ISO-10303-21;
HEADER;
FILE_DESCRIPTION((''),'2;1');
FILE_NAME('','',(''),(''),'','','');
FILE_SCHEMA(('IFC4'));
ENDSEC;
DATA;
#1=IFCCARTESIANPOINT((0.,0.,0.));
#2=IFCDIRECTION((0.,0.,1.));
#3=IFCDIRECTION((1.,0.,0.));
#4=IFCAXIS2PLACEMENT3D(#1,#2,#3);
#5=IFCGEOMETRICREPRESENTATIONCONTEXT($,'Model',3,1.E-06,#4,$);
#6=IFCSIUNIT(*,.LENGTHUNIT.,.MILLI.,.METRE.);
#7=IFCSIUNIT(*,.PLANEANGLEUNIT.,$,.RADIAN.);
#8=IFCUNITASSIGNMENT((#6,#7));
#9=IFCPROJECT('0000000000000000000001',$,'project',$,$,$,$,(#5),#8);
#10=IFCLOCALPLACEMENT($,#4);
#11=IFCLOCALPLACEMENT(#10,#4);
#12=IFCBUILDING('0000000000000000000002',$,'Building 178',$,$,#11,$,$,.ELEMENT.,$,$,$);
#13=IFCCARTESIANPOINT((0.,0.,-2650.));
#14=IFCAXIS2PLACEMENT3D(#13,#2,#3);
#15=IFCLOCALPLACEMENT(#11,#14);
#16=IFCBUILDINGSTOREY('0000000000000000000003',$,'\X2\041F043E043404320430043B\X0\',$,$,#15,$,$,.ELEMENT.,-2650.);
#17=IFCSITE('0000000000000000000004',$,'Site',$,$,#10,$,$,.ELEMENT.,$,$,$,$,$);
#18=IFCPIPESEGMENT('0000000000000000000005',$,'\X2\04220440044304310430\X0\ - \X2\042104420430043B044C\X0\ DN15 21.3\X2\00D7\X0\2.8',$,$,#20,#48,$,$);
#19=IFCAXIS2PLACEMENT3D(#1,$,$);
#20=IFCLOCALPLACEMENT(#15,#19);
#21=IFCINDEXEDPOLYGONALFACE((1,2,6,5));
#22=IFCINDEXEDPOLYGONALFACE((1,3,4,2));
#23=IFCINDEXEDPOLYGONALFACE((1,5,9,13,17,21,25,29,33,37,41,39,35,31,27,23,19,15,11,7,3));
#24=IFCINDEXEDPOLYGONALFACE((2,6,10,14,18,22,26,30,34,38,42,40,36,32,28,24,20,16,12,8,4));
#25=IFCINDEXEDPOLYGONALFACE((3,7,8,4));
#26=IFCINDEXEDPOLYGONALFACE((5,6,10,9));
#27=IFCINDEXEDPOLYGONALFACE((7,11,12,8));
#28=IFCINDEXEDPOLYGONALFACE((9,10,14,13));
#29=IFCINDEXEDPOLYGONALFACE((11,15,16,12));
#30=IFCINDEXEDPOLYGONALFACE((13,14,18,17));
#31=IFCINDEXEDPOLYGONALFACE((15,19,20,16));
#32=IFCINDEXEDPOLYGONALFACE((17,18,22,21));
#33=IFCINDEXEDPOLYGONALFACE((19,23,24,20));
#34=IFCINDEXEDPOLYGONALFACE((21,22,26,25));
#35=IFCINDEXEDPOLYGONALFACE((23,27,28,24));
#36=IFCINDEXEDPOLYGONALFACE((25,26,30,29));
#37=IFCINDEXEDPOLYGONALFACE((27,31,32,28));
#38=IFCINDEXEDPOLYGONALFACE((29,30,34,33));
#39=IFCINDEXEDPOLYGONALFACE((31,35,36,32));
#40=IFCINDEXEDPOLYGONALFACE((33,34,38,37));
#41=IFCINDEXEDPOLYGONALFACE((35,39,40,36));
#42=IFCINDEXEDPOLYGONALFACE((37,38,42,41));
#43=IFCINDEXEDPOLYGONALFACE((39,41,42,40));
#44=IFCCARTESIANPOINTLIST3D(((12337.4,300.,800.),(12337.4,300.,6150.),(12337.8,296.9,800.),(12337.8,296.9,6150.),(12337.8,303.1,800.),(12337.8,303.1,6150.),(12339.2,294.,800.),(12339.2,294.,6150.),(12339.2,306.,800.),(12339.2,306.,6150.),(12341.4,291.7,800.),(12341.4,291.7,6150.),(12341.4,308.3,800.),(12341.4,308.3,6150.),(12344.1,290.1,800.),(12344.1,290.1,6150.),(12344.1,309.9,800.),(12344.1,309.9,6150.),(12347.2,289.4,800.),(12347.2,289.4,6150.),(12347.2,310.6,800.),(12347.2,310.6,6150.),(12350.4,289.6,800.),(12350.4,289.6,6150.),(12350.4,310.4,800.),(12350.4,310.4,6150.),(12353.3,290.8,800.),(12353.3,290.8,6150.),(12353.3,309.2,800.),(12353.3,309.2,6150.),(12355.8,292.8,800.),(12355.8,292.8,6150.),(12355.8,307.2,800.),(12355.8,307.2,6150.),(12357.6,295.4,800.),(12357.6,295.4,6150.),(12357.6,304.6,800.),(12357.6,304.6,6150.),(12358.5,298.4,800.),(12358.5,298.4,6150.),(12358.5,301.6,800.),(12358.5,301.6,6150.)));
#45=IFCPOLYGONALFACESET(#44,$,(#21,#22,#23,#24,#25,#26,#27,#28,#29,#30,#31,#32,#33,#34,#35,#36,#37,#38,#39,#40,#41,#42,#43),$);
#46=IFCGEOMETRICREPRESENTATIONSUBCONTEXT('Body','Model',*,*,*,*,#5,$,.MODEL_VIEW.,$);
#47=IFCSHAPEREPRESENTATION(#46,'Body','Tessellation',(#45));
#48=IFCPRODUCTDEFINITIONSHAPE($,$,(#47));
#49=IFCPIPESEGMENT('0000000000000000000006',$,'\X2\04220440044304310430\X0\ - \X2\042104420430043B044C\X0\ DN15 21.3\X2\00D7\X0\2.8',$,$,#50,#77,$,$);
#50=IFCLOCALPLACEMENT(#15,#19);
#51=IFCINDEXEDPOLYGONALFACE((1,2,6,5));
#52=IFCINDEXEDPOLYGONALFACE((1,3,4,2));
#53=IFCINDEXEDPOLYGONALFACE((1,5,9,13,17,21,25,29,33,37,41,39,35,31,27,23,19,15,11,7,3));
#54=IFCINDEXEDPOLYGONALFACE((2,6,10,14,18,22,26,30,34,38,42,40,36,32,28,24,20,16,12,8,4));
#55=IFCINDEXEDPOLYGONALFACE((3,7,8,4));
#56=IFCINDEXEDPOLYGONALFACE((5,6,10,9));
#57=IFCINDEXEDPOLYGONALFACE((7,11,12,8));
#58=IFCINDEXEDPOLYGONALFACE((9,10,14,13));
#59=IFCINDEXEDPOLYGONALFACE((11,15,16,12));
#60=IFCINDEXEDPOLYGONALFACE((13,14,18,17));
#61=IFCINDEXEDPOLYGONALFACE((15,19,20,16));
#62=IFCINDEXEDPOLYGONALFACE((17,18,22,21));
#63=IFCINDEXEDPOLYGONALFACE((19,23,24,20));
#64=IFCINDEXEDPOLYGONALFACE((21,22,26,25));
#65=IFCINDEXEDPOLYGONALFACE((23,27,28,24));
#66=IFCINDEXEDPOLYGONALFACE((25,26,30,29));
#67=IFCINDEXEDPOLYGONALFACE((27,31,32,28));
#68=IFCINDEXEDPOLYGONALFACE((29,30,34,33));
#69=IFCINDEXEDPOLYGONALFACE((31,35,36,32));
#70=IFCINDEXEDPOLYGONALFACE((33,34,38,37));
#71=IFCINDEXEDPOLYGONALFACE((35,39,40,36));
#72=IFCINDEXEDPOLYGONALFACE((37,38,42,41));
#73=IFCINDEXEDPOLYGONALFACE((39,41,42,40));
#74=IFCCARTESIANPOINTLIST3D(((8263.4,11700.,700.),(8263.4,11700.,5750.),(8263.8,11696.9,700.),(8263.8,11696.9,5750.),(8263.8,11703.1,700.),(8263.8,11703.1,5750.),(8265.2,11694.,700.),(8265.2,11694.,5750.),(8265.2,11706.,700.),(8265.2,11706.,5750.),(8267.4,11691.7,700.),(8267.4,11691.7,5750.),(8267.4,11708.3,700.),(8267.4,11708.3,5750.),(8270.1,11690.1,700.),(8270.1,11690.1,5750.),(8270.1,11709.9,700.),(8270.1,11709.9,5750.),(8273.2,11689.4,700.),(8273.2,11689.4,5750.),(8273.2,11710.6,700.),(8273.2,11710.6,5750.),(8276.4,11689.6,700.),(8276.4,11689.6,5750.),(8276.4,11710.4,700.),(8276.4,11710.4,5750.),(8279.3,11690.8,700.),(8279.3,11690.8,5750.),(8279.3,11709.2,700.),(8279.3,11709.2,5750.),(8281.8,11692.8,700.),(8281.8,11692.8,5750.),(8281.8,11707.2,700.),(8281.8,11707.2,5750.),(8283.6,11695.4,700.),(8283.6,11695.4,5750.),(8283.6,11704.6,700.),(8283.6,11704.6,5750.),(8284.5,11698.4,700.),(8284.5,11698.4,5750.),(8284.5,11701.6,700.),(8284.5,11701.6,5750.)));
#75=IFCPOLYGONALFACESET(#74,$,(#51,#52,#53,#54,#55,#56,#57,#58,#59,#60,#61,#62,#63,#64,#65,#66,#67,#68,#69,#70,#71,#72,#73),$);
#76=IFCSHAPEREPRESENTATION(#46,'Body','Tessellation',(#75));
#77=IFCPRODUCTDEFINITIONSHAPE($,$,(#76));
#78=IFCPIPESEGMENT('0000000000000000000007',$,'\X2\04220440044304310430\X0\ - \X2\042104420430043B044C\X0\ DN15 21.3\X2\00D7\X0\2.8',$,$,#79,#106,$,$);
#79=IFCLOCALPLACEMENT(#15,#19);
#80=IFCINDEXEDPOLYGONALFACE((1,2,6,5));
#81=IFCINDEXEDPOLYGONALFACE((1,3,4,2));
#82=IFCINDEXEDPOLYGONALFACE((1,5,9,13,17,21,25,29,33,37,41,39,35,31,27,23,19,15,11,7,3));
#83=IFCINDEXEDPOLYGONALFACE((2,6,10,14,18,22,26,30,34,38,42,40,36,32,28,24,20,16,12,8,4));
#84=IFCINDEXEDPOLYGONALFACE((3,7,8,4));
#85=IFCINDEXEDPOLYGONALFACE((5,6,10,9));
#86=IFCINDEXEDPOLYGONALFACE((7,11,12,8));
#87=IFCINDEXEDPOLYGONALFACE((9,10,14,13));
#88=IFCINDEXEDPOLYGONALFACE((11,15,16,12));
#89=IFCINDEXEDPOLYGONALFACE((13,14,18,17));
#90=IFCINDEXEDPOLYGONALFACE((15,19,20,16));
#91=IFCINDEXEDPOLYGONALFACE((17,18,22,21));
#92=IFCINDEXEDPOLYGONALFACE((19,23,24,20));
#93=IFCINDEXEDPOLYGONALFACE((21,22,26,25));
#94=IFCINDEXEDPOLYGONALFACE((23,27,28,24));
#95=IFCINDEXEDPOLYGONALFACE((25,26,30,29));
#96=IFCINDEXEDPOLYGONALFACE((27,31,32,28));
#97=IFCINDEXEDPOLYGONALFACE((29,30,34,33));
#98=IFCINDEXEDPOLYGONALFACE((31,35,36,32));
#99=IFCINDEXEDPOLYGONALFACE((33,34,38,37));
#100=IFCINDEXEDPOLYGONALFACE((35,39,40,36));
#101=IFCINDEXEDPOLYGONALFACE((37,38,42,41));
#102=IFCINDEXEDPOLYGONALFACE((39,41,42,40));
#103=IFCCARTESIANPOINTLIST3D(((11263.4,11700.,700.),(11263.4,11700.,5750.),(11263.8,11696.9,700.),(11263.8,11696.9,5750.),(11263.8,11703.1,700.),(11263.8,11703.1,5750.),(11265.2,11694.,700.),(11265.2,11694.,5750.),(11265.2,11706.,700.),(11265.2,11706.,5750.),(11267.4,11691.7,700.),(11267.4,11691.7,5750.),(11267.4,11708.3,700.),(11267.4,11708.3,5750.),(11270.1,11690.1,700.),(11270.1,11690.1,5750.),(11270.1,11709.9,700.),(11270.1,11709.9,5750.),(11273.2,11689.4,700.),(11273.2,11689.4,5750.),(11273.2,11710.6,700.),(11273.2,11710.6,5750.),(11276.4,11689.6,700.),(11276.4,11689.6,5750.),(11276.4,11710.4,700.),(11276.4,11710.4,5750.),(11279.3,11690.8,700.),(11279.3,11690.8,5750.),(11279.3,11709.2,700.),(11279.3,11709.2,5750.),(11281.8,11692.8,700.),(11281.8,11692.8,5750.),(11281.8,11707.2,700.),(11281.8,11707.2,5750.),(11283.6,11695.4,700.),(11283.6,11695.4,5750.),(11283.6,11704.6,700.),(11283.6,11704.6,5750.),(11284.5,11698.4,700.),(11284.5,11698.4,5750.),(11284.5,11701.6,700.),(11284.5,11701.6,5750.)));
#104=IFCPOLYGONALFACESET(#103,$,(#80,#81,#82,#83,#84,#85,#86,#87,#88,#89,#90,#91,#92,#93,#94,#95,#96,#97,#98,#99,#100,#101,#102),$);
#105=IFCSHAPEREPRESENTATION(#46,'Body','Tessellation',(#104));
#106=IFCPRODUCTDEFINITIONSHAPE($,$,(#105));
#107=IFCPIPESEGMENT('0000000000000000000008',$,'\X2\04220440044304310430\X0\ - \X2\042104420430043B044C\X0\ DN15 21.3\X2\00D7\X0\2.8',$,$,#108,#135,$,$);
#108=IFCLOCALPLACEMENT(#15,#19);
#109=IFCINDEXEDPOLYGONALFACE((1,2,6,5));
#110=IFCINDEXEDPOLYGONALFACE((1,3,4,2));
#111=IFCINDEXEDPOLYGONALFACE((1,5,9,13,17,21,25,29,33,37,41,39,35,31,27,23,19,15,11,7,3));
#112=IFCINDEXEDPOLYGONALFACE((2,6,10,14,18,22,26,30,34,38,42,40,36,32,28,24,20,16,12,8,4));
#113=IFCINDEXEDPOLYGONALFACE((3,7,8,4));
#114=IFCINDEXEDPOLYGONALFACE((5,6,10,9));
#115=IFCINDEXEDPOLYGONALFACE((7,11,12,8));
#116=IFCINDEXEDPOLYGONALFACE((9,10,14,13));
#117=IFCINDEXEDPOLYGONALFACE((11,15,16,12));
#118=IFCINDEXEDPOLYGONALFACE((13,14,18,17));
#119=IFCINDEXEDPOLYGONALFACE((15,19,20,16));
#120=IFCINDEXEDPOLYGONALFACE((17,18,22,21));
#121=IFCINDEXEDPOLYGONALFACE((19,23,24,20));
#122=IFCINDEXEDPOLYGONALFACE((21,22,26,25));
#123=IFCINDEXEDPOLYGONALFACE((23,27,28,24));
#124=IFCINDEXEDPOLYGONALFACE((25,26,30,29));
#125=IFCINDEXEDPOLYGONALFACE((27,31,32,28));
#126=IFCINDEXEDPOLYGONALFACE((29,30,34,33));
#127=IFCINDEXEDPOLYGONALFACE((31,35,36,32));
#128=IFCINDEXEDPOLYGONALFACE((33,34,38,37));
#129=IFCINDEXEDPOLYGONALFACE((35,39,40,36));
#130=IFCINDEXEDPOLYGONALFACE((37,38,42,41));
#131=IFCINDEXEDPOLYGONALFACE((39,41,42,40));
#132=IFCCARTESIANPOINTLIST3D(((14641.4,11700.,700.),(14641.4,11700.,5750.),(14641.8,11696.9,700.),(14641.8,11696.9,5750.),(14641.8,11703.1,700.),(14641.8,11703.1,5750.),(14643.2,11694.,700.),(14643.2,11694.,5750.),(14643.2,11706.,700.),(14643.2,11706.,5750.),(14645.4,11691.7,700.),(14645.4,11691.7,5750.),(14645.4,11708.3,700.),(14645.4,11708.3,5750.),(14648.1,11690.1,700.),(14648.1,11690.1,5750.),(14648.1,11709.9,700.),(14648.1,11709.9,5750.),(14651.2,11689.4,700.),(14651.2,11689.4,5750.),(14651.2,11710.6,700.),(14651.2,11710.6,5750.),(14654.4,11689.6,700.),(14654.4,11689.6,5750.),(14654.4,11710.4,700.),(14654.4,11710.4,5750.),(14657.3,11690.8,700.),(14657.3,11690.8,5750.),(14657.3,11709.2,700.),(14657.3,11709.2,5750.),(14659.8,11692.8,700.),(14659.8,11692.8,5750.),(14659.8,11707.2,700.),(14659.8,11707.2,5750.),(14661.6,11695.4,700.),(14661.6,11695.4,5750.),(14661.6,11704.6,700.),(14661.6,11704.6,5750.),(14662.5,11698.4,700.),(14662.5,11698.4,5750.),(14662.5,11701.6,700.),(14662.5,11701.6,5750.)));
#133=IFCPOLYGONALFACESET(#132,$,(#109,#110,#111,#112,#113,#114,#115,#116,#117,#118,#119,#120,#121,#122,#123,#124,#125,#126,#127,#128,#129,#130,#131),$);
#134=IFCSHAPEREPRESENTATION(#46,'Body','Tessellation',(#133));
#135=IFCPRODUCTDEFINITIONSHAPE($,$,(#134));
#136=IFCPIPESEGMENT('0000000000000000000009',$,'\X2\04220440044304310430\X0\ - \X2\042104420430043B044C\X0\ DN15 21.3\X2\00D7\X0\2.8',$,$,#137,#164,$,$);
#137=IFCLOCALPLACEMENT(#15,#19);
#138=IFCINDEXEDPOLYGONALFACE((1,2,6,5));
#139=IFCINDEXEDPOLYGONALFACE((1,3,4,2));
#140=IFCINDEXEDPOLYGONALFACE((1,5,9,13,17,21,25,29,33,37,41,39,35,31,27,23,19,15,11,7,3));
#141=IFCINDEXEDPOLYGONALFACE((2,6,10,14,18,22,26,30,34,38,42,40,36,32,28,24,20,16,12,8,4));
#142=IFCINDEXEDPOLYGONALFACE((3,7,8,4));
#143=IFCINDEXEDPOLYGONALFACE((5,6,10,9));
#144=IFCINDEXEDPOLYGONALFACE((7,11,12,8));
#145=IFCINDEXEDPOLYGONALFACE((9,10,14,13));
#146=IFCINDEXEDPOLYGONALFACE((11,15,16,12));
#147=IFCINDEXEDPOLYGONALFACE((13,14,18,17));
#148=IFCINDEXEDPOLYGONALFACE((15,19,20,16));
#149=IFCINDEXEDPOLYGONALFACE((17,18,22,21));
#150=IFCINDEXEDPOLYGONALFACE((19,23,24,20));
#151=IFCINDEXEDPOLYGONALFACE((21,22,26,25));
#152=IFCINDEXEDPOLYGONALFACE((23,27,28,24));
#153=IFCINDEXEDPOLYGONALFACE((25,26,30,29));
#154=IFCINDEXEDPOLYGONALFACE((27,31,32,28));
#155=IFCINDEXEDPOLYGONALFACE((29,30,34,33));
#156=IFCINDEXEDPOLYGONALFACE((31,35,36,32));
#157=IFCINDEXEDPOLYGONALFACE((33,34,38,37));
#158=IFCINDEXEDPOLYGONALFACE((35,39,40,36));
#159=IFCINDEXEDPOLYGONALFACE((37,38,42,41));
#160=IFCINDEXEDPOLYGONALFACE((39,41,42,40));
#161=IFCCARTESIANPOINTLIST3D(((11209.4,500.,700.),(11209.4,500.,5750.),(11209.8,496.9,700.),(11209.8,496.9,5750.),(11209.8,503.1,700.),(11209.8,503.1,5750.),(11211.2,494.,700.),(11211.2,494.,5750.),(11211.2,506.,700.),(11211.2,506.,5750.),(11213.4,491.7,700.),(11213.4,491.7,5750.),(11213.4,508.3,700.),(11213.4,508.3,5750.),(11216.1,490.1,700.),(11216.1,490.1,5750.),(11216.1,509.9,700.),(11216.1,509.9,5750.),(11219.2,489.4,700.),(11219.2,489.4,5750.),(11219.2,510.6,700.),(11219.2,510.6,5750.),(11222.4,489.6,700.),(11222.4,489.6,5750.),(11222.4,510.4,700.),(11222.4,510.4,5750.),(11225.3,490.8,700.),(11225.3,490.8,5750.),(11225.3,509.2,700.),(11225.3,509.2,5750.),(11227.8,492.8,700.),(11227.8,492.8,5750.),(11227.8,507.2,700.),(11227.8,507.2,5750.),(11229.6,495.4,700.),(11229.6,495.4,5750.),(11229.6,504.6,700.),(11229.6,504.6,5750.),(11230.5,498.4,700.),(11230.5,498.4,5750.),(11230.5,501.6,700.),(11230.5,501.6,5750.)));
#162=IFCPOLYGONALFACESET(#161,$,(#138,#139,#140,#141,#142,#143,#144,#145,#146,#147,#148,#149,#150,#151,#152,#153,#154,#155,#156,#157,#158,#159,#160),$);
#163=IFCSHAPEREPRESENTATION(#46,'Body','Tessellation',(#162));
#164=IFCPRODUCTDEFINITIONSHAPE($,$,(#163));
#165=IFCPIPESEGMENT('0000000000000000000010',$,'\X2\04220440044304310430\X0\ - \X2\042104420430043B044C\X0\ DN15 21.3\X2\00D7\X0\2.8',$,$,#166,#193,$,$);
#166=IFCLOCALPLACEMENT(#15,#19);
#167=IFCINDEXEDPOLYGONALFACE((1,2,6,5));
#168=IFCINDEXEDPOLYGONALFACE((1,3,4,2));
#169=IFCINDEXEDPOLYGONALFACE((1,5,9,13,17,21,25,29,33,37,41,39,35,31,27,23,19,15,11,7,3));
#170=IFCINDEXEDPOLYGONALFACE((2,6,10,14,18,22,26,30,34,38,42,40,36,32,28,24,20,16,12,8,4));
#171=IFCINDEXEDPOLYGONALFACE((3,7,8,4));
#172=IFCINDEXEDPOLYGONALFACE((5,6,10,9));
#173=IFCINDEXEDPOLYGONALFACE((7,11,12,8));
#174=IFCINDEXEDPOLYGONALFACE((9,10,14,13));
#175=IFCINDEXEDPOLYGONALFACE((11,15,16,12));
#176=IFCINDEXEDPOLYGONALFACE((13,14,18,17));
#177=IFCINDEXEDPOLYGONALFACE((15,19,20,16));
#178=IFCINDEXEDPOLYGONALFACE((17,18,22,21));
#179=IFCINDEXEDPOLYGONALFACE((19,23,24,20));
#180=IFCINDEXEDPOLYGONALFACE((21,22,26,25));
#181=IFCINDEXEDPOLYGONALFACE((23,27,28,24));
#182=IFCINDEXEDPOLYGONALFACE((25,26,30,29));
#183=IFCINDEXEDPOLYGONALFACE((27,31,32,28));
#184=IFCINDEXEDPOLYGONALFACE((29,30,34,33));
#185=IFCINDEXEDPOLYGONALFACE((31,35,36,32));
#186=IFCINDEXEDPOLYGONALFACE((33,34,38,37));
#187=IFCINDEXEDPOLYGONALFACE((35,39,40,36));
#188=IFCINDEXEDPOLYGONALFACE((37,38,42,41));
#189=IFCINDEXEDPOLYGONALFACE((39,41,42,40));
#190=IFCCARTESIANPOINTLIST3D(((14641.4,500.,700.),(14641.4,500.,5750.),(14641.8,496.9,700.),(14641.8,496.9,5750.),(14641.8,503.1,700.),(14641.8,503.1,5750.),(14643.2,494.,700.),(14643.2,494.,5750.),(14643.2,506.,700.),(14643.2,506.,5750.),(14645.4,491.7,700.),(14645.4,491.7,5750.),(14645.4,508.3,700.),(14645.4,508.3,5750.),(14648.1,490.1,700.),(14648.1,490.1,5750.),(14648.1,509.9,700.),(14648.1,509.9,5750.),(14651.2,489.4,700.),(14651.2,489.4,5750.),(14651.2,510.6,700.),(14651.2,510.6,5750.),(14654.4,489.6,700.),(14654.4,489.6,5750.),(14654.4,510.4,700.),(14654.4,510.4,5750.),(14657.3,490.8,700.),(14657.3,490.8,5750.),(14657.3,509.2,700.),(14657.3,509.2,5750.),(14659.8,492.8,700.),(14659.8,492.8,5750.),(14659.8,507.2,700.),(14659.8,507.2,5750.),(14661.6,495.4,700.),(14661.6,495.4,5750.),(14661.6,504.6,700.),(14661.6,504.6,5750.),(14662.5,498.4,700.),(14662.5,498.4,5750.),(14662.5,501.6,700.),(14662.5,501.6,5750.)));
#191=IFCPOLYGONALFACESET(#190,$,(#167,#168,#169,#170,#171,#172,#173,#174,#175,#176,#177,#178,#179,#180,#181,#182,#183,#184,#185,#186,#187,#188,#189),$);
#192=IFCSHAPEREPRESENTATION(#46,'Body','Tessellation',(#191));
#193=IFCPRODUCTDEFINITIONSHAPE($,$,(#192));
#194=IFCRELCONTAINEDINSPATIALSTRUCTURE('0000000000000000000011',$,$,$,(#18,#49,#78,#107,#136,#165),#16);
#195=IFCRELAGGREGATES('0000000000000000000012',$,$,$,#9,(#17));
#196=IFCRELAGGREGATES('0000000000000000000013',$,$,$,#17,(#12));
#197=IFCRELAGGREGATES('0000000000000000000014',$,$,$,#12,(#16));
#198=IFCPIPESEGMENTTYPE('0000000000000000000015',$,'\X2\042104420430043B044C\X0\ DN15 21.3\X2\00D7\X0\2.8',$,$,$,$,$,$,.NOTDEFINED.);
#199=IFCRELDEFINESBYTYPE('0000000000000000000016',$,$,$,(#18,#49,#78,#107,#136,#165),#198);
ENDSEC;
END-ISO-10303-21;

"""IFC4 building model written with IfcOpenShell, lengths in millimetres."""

from ifc_helpers import new_model, entity, si_unit, frame, origin_with_axes, place, context, subcontext, project, spatial, source, transform, mapped, type_object, element, save


model = new_model("IFC4")

# Units and contexts
model_context = context("Model", 3, precision=1e-06, world=origin_with_axes())
body_context = subcontext(model_context, "Body", "Model", "MODEL_VIEW")
ifc_project = project(units=[si_unit("LENGTHUNIT", "METRE", prefix="MILLI"), si_unit("PLANEANGLEUNIT", "RADIAN")], contexts=[model_context])

# Site, building, storey
site_placement = place(None, origin_with_axes())
site = spatial("IfcSite", under=ifc_project, at=site_placement, Name="Site", CompositionType="ELEMENT")
building_placement = place(site_placement, origin_with_axes())
building = spatial("IfcBuilding", under=site, at=building_placement, Name="Building 178", CompositionType="ELEMENT")
storey_placement = place(building_placement, frame((0.0, 0.0, -2650.0), z_axis=(0.0, 0.0, 1.0), x_axis=(1.0, 0.0, 0.0)))
storey = spatial("IfcBuildingStorey", under=building, at=storey_placement, Name="Подвал", CompositionType="ELEMENT", Elevation=-2650.0)

# Pipe segments
pipe_segment_type_1 = type_object("IfcPipeSegmentType", Name="Сталь DN15 21.3×2.8", PredefinedType="NOTDEFINED")
shared_shape_1 = source(origin_with_axes(), body_context, "Body", "AdvancedSweptSolid", [
    entity("IfcSweptDiskSolid", entity("IfcIndexedPolyCurve", entity("IfcCartesianPointList3D", [[0.0, 0.0, 0.0], [0.0, 0.0, -5350.0]]), [entity("IfcLineIndex", [1, 2])]), 10.7),
])
for number, where, z_axis, x_axis, name in (
    (1, (12348.0, 300.0, 6150.0), (0.0, 0.0, 1.0), (1.0, 0.0, 0.0), "Труба - Сталь DN15 21.3×2.8"),
):
    element("IfcPipeSegment", number, at=place(storey_placement, frame(where, z_axis=z_axis, x_axis=x_axis)), inside=storey, type_object=pipe_segment_type_1, Name=name, context=body_context, shape_type="MappedRepresentation", body=[
        mapped(shared_shape_1, transform((0.0, 0.0, 0.0), x_axis=(1.0, 0.0, 0.0), y_axis=(0.0, 1.0, 0.0), z_axis=(0.0, 0.0, 1.0), scale=1.0)),
    ])
shared_shape_2 = source(origin_with_axes(), body_context, "Body", "AdvancedSweptSolid", [
    entity("IfcSweptDiskSolid", entity("IfcIndexedPolyCurve", entity("IfcCartesianPointList3D", [[0.0, 0.0, 0.0], [0.0, 0.0, -5050.0]]), [entity("IfcLineIndex", [1, 2])]), 10.7),
])
for number, where, z_axis, x_axis, name in (
    (2, (8274.0, 11700.0, 5750.0), (0.0, 0.0, 1.0), (1.0, 0.0, 0.0), "Труба - Сталь DN15 21.3×2.8"),
    (3, (11274.0, 11700.0, 5750.0), (0.0, 0.0, 1.0), (1.0, 0.0, 0.0), "Труба - Сталь DN15 21.3×2.8"),
    (4, (14652.0, 11700.0, 5750.0), (0.0, 0.0, 1.0), (1.0, 0.0, 0.0), "Труба - Сталь DN15 21.3×2.8"),
    (5, (11220.0, 500.0, 5750.0), (0.0, 0.0, 1.0), (1.0, 0.0, 0.0), "Труба - Сталь DN15 21.3×2.8"),
    (6, (14652.0, 500.0, 5750.0), (0.0, 0.0, 1.0), (1.0, 0.0, 0.0), "Труба - Сталь DN15 21.3×2.8"),
):
    element("IfcPipeSegment", number, at=place(storey_placement, frame(where, z_axis=z_axis, x_axis=x_axis)), inside=storey, type_object=pipe_segment_type_1, Name=name, context=body_context, shape_type="MappedRepresentation", body=[
        mapped(shared_shape_2, transform((0.0, 0.0, 0.0), x_axis=(1.0, 0.0, 0.0), y_axis=(0.0, 1.0, 0.0), z_axis=(0.0, 0.0, 1.0), scale=1.0)),
    ])

save(model, "model.ifc")
